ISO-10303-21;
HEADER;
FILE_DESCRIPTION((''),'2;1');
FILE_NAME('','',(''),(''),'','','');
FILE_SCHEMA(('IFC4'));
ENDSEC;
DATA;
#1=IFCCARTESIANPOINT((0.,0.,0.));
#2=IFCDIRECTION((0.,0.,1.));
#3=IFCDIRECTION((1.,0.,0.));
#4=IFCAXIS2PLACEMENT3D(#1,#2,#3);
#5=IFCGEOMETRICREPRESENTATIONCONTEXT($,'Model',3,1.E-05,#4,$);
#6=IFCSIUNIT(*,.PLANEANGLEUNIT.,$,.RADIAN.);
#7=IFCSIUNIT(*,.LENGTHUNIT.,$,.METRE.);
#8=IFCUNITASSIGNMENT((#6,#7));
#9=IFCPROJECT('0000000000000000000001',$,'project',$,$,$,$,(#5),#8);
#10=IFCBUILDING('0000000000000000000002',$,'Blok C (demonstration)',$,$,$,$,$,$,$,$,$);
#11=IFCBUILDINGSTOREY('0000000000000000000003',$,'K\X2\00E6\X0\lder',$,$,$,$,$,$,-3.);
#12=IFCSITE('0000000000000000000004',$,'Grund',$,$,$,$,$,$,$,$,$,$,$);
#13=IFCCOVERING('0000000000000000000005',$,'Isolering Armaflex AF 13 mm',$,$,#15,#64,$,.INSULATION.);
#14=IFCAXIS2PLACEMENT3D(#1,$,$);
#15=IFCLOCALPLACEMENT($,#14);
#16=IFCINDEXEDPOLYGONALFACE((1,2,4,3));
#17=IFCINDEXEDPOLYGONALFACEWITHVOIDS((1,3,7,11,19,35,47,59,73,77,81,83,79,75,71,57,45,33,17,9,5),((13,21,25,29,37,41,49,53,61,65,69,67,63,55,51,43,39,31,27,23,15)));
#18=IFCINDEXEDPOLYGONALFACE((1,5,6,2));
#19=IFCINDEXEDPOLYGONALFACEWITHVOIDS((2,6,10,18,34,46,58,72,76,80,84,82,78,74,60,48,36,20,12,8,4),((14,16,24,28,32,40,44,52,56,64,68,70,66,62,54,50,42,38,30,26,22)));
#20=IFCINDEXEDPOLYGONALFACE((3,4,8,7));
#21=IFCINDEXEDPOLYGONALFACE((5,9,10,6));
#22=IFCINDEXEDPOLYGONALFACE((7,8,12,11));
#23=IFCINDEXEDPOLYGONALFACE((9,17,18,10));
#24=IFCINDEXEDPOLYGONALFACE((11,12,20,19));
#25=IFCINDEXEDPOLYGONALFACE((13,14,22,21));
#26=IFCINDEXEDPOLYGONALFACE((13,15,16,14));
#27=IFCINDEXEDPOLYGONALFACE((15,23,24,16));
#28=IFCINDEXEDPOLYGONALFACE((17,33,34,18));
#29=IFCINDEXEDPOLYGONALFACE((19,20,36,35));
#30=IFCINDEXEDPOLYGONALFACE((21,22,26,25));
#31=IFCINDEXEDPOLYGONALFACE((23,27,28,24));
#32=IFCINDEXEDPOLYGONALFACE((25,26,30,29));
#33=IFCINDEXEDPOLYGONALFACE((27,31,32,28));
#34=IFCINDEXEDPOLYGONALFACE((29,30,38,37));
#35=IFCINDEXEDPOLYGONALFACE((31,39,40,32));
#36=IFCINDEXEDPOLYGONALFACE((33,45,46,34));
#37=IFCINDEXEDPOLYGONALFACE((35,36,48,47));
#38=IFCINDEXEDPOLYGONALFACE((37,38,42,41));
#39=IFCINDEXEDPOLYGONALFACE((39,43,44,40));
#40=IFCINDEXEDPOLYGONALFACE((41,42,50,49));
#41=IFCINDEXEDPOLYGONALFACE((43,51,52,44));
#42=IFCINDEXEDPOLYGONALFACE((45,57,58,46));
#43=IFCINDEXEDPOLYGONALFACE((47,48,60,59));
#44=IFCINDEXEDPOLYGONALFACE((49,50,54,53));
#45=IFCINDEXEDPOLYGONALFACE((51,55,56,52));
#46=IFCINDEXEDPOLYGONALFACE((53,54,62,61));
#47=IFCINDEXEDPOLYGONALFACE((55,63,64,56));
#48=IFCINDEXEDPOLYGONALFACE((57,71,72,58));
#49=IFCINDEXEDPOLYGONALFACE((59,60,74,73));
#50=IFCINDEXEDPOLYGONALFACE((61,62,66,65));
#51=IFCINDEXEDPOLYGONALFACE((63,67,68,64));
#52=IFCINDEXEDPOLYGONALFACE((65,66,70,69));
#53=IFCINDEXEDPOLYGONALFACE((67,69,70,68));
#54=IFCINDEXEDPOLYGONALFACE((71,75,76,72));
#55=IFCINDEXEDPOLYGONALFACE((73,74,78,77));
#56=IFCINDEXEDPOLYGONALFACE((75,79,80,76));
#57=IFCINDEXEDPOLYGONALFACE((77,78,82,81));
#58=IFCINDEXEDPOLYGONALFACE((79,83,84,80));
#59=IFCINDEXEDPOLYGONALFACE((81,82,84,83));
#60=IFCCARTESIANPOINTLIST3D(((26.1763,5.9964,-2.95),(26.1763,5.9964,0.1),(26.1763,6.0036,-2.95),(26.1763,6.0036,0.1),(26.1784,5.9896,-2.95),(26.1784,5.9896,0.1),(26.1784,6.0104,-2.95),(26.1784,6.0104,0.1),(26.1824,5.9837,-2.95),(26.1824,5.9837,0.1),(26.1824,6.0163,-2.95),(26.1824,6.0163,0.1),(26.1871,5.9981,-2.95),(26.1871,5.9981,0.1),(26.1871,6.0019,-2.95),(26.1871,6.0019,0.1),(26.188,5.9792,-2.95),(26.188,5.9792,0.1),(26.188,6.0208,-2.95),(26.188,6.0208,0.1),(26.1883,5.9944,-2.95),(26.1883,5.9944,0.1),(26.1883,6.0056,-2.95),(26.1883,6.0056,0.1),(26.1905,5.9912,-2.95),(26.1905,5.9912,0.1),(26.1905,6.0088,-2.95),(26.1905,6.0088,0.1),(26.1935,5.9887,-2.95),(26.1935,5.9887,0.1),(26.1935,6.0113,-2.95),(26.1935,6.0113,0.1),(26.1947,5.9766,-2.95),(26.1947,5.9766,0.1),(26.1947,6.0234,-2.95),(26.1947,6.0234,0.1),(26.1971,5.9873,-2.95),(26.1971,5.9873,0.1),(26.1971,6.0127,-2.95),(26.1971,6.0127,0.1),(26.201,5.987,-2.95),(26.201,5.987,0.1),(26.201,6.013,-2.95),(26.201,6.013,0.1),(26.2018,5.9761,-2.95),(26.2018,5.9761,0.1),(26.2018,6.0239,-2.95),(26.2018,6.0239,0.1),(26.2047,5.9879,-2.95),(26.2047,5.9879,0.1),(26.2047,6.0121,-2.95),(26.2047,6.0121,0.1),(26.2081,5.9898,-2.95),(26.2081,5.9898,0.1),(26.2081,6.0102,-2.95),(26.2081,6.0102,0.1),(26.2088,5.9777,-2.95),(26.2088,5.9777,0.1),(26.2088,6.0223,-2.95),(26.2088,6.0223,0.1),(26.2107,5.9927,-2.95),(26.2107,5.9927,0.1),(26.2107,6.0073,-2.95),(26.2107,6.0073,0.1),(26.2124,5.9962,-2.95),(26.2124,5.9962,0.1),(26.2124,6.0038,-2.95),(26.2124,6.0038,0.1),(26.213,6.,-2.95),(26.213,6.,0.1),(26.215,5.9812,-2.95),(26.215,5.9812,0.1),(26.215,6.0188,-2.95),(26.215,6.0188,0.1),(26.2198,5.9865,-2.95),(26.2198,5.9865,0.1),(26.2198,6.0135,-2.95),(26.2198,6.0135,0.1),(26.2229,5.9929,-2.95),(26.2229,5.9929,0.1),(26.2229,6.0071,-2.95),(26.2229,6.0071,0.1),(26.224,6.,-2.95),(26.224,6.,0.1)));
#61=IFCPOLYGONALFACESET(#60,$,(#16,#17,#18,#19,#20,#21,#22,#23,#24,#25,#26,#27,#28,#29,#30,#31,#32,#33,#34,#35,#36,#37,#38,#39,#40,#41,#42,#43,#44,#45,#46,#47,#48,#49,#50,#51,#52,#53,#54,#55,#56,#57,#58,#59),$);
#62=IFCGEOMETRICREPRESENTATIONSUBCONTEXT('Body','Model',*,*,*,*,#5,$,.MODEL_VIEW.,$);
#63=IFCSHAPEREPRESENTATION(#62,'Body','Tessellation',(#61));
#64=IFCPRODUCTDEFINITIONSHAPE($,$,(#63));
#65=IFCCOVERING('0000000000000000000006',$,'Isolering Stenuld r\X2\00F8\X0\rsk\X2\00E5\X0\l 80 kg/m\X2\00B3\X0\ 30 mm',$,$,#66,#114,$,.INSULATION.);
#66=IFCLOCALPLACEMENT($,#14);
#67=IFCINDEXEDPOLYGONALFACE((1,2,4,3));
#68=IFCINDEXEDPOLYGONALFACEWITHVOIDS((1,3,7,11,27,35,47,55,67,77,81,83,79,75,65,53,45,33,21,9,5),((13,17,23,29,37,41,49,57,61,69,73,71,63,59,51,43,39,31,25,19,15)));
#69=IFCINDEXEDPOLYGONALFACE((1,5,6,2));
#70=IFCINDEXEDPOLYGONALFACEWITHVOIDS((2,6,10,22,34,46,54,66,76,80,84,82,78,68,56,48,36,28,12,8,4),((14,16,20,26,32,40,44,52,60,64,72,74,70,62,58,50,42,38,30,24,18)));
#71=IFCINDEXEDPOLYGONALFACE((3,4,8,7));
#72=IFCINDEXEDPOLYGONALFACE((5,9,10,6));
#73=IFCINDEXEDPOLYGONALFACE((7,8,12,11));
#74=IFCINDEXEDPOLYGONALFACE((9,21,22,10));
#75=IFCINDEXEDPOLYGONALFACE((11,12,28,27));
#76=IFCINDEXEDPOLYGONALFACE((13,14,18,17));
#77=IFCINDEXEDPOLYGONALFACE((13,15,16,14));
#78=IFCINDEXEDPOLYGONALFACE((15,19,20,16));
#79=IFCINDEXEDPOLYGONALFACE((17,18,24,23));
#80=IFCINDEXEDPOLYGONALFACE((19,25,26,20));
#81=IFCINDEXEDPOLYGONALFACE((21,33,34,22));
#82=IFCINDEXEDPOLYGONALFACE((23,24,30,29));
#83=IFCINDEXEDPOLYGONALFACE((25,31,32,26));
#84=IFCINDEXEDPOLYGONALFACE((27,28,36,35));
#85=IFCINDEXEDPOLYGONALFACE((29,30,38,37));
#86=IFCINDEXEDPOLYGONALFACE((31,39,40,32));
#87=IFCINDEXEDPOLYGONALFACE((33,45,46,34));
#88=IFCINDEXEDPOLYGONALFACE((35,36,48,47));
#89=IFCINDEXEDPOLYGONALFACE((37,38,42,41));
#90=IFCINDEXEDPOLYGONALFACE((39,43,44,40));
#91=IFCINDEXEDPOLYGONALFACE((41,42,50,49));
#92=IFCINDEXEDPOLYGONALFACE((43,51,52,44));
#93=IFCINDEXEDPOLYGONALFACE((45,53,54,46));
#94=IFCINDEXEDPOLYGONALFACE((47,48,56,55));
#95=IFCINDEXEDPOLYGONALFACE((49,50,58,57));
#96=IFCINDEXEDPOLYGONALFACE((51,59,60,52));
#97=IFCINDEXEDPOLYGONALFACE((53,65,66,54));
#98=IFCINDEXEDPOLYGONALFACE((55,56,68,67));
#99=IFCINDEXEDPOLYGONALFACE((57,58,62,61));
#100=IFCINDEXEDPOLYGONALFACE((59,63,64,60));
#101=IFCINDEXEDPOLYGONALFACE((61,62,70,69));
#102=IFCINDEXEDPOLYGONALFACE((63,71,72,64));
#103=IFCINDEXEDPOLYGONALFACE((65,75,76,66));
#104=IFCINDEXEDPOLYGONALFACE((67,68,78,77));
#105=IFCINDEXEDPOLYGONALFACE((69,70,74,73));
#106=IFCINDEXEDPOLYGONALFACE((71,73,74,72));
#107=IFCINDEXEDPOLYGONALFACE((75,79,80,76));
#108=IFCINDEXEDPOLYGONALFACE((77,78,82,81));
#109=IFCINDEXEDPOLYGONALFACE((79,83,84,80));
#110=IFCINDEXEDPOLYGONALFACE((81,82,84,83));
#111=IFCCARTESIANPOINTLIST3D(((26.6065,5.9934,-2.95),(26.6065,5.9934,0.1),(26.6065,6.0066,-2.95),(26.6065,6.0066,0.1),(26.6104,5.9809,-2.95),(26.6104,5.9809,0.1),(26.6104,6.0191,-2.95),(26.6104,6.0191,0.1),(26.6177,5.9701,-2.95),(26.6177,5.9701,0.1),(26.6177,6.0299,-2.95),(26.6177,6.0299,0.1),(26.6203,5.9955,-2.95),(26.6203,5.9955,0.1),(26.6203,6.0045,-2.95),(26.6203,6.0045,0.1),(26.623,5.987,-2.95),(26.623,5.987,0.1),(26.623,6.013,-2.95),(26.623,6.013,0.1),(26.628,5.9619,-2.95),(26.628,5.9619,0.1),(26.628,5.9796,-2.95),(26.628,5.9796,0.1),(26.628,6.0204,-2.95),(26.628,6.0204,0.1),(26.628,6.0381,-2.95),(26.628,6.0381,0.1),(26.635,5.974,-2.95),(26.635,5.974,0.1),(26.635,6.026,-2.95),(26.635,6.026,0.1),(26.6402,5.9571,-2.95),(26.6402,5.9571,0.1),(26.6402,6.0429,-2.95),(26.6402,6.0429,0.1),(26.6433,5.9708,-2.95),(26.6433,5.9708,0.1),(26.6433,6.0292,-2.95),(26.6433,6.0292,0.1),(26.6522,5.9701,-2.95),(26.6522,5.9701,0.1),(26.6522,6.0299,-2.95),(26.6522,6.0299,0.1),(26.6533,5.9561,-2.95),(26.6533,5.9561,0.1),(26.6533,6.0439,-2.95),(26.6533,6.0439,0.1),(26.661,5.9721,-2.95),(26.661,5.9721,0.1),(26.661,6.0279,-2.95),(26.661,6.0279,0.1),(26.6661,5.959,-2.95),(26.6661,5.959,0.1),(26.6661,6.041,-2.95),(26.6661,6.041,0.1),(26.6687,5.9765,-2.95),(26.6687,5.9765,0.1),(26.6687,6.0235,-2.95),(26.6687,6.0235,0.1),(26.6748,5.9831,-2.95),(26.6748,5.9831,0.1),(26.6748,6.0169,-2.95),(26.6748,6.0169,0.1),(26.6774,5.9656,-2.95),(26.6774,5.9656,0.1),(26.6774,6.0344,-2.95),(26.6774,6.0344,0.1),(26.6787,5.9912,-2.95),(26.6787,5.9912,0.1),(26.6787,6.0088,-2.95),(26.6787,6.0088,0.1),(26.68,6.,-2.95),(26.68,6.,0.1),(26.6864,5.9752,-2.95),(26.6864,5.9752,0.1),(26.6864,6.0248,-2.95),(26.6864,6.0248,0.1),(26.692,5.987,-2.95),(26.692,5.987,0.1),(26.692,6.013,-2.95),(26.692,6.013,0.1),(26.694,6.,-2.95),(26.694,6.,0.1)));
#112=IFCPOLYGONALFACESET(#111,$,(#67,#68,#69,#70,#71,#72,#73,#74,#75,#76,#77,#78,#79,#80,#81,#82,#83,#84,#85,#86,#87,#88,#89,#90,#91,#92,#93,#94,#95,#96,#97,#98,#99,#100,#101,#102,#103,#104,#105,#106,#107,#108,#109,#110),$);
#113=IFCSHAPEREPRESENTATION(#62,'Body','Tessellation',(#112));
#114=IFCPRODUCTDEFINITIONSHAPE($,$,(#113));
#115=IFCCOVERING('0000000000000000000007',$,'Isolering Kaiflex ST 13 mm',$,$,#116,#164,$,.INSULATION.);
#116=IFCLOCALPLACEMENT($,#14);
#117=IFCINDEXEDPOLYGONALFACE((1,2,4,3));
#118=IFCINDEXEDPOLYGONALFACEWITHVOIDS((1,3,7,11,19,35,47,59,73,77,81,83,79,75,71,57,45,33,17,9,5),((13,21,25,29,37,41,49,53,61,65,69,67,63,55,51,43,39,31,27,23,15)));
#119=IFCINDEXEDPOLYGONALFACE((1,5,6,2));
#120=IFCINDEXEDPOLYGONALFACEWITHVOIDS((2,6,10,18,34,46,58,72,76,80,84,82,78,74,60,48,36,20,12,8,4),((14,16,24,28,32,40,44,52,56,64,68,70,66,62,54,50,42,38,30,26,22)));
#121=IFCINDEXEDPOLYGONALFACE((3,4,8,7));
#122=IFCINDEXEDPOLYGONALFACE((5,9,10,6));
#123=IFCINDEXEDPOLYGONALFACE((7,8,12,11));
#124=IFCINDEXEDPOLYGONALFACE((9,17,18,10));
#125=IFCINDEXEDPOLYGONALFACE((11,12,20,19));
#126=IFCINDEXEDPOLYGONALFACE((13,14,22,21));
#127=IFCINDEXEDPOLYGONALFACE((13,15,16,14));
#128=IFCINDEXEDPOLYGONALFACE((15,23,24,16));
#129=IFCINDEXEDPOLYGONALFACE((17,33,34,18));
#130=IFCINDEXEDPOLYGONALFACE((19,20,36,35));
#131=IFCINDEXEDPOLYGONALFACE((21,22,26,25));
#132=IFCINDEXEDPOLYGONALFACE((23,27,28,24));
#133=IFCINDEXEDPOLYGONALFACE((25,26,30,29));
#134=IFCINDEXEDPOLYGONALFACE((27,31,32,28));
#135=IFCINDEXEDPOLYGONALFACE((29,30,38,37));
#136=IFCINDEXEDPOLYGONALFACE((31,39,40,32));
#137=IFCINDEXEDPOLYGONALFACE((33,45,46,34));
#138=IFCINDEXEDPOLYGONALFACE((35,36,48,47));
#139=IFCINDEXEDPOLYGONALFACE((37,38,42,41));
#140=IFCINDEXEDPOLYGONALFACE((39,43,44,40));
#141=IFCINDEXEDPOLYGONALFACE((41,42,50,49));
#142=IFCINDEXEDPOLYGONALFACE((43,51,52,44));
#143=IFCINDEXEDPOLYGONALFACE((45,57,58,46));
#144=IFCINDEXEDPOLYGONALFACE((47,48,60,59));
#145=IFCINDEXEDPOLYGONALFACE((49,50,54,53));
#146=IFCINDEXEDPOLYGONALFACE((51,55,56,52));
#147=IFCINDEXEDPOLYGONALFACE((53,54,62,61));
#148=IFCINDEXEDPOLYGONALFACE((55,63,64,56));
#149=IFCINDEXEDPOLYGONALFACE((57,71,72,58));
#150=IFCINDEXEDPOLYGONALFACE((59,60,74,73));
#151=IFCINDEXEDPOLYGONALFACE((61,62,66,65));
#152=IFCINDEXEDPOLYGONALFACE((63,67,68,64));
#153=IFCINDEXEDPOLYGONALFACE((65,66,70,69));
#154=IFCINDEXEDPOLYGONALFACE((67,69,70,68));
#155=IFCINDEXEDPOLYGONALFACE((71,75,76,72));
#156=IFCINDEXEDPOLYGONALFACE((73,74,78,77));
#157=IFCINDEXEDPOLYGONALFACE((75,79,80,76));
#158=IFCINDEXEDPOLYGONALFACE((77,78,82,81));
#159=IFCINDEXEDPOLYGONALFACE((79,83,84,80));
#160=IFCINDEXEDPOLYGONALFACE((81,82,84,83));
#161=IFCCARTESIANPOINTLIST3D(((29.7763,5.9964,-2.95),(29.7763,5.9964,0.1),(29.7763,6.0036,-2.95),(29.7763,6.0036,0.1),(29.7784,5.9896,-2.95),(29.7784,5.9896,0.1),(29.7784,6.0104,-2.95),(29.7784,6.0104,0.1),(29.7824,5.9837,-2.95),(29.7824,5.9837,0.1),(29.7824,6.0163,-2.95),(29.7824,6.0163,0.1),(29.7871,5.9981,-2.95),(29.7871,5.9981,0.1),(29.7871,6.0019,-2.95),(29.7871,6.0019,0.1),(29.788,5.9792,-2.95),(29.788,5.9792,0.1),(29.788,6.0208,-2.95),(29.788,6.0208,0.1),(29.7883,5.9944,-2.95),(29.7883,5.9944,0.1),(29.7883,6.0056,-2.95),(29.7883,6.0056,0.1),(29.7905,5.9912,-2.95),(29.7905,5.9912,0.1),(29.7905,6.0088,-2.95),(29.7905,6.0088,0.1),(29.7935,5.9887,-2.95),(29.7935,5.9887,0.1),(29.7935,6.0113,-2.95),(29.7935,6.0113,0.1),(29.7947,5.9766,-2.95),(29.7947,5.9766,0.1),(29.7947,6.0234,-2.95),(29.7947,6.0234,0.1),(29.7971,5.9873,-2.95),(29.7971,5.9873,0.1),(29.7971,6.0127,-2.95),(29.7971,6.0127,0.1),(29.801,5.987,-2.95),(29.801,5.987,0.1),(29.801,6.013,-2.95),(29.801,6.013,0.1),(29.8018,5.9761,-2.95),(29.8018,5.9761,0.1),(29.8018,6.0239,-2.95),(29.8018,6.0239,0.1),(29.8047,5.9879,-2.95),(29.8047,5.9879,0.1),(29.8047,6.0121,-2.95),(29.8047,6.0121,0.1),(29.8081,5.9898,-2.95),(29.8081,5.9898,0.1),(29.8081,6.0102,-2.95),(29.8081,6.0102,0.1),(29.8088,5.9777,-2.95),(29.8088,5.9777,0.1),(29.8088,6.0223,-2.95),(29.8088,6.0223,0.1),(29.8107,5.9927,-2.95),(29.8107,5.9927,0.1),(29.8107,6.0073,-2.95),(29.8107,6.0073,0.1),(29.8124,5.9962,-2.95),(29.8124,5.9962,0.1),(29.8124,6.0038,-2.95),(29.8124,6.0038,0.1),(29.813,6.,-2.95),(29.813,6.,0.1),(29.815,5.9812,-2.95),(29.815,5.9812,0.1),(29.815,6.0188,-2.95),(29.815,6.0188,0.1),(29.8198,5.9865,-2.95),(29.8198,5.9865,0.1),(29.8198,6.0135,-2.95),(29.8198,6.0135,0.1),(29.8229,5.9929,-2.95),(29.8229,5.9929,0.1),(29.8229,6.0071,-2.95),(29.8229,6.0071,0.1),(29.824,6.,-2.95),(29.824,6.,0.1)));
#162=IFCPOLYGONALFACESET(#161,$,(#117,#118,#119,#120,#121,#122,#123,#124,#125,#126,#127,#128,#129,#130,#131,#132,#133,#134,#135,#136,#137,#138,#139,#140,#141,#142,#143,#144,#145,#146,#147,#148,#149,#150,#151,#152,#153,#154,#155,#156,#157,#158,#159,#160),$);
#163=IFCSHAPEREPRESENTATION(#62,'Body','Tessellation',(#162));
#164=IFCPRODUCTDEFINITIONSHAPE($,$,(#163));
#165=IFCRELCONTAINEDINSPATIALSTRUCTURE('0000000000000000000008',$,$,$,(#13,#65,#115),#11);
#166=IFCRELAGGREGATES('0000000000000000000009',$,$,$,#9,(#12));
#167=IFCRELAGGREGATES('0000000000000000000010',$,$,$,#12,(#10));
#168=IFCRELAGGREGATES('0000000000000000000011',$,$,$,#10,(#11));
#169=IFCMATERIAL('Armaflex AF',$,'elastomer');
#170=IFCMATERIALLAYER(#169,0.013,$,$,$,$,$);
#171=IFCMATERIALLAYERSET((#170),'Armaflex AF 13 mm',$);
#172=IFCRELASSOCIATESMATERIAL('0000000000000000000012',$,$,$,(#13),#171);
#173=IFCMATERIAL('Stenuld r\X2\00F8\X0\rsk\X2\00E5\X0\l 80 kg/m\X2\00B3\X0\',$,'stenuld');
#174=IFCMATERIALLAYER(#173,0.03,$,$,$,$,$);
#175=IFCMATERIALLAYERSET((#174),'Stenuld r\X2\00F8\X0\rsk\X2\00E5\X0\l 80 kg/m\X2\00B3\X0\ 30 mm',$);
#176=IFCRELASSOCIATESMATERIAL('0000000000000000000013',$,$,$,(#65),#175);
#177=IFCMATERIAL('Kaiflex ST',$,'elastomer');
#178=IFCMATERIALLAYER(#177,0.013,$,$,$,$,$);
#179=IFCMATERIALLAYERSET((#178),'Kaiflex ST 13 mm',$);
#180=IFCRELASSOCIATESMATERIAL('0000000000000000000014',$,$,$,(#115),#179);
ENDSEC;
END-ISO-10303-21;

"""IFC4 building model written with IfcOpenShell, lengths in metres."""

from ifc_helpers import new_model, si_unit, frame, origin_with_axes, place, context, subcontext, project, spatial, hollow_circle, extrude, material, layer, layer_set, element, save


model = new_model("IFC4")

# Units and contexts
model_context = context("Model", 3, precision=1e-05, world=origin_with_axes())
body_context = subcontext(model_context, "Body", "Model", "MODEL_VIEW")
ifc_project = project(units=[si_unit("PLANEANGLEUNIT", "RADIAN"), si_unit("LENGTHUNIT", "METRE")], contexts=[model_context])

# Site, building, storey
site = spatial("IfcSite", under=ifc_project, Name="Grund")
building = spatial("IfcBuilding", under=site, Name="Blok C (demonstration)")
storey = spatial("IfcBuildingStorey", under=building, Name="Kælder", Elevation=-3.0)

# Coverings
ifc_material_1 = material(Name="Armaflex AF", Category="elastomer")
ifc_layer_1 = layer(ifc_material_1, 0.013)
ifc_layer_set_1 = layer_set([ifc_layer_1], Name="Armaflex AF 13 mm")
covering_1_placement = place(None, origin_with_axes())
element("IfcCovering", 1, at=covering_1_placement, inside=storey, material=ifc_layer_set_1, Name="Isolering Armaflex AF 13 mm", PredefinedType="INSULATION", context=body_context, shape_type="SweptSolid", body=[
    extrude(hollow_circle(Radius=0.024, WallThickness=0.011), frame((26.2, 6.0, -2.95), z_axis=(0.0, 0.0, 1.0), x_axis=(1.0, 0.0, 0.0)), (0.0, 0.0, 1.0), 3.05),
])
ifc_material_2 = material(Name="Stenuld rørskål 80 kg/m³", Category="stenuld")
ifc_layer_2 = layer(ifc_material_2, 0.03)
ifc_layer_set_2 = layer_set([ifc_layer_2], Name="Stenuld rørskål 80 kg/m³ 30 mm")
covering_2_placement = place(None, origin_with_axes())
element("IfcCovering", 2, at=covering_2_placement, inside=storey, material=ifc_layer_set_2, Name="Isolering Stenuld rørskål 80 kg/m³ 30 mm", PredefinedType="INSULATION", context=body_context, shape_type="SweptSolid", body=[
    extrude(hollow_circle(Radius=0.044, WallThickness=0.014), frame((26.65, 6.0, -2.95), z_axis=(0.0, 0.0, 1.0), x_axis=(1.0, 0.0, 0.0)), (0.0, 0.0, 1.0), 3.05),
])
ifc_material_3 = material(Name="Kaiflex ST", Category="elastomer")
ifc_layer_3 = layer(ifc_material_3, 0.013)
ifc_layer_set_3 = layer_set([ifc_layer_3], Name="Kaiflex ST 13 mm")
covering_3_placement = place(None, origin_with_axes())
element("IfcCovering", 3, at=covering_3_placement, inside=storey, material=ifc_layer_set_3, Name="Isolering Kaiflex ST 13 mm", PredefinedType="INSULATION", context=body_context, shape_type="SweptSolid", body=[
    extrude(hollow_circle(Radius=0.024, WallThickness=0.011), frame((29.8, 6.0, -2.95), z_axis=(0.0, 0.0, 1.0), x_axis=(1.0, 0.0, 0.0)), (0.0, 0.0, 1.0), 3.05),
])

save(model, "model.ifc")
